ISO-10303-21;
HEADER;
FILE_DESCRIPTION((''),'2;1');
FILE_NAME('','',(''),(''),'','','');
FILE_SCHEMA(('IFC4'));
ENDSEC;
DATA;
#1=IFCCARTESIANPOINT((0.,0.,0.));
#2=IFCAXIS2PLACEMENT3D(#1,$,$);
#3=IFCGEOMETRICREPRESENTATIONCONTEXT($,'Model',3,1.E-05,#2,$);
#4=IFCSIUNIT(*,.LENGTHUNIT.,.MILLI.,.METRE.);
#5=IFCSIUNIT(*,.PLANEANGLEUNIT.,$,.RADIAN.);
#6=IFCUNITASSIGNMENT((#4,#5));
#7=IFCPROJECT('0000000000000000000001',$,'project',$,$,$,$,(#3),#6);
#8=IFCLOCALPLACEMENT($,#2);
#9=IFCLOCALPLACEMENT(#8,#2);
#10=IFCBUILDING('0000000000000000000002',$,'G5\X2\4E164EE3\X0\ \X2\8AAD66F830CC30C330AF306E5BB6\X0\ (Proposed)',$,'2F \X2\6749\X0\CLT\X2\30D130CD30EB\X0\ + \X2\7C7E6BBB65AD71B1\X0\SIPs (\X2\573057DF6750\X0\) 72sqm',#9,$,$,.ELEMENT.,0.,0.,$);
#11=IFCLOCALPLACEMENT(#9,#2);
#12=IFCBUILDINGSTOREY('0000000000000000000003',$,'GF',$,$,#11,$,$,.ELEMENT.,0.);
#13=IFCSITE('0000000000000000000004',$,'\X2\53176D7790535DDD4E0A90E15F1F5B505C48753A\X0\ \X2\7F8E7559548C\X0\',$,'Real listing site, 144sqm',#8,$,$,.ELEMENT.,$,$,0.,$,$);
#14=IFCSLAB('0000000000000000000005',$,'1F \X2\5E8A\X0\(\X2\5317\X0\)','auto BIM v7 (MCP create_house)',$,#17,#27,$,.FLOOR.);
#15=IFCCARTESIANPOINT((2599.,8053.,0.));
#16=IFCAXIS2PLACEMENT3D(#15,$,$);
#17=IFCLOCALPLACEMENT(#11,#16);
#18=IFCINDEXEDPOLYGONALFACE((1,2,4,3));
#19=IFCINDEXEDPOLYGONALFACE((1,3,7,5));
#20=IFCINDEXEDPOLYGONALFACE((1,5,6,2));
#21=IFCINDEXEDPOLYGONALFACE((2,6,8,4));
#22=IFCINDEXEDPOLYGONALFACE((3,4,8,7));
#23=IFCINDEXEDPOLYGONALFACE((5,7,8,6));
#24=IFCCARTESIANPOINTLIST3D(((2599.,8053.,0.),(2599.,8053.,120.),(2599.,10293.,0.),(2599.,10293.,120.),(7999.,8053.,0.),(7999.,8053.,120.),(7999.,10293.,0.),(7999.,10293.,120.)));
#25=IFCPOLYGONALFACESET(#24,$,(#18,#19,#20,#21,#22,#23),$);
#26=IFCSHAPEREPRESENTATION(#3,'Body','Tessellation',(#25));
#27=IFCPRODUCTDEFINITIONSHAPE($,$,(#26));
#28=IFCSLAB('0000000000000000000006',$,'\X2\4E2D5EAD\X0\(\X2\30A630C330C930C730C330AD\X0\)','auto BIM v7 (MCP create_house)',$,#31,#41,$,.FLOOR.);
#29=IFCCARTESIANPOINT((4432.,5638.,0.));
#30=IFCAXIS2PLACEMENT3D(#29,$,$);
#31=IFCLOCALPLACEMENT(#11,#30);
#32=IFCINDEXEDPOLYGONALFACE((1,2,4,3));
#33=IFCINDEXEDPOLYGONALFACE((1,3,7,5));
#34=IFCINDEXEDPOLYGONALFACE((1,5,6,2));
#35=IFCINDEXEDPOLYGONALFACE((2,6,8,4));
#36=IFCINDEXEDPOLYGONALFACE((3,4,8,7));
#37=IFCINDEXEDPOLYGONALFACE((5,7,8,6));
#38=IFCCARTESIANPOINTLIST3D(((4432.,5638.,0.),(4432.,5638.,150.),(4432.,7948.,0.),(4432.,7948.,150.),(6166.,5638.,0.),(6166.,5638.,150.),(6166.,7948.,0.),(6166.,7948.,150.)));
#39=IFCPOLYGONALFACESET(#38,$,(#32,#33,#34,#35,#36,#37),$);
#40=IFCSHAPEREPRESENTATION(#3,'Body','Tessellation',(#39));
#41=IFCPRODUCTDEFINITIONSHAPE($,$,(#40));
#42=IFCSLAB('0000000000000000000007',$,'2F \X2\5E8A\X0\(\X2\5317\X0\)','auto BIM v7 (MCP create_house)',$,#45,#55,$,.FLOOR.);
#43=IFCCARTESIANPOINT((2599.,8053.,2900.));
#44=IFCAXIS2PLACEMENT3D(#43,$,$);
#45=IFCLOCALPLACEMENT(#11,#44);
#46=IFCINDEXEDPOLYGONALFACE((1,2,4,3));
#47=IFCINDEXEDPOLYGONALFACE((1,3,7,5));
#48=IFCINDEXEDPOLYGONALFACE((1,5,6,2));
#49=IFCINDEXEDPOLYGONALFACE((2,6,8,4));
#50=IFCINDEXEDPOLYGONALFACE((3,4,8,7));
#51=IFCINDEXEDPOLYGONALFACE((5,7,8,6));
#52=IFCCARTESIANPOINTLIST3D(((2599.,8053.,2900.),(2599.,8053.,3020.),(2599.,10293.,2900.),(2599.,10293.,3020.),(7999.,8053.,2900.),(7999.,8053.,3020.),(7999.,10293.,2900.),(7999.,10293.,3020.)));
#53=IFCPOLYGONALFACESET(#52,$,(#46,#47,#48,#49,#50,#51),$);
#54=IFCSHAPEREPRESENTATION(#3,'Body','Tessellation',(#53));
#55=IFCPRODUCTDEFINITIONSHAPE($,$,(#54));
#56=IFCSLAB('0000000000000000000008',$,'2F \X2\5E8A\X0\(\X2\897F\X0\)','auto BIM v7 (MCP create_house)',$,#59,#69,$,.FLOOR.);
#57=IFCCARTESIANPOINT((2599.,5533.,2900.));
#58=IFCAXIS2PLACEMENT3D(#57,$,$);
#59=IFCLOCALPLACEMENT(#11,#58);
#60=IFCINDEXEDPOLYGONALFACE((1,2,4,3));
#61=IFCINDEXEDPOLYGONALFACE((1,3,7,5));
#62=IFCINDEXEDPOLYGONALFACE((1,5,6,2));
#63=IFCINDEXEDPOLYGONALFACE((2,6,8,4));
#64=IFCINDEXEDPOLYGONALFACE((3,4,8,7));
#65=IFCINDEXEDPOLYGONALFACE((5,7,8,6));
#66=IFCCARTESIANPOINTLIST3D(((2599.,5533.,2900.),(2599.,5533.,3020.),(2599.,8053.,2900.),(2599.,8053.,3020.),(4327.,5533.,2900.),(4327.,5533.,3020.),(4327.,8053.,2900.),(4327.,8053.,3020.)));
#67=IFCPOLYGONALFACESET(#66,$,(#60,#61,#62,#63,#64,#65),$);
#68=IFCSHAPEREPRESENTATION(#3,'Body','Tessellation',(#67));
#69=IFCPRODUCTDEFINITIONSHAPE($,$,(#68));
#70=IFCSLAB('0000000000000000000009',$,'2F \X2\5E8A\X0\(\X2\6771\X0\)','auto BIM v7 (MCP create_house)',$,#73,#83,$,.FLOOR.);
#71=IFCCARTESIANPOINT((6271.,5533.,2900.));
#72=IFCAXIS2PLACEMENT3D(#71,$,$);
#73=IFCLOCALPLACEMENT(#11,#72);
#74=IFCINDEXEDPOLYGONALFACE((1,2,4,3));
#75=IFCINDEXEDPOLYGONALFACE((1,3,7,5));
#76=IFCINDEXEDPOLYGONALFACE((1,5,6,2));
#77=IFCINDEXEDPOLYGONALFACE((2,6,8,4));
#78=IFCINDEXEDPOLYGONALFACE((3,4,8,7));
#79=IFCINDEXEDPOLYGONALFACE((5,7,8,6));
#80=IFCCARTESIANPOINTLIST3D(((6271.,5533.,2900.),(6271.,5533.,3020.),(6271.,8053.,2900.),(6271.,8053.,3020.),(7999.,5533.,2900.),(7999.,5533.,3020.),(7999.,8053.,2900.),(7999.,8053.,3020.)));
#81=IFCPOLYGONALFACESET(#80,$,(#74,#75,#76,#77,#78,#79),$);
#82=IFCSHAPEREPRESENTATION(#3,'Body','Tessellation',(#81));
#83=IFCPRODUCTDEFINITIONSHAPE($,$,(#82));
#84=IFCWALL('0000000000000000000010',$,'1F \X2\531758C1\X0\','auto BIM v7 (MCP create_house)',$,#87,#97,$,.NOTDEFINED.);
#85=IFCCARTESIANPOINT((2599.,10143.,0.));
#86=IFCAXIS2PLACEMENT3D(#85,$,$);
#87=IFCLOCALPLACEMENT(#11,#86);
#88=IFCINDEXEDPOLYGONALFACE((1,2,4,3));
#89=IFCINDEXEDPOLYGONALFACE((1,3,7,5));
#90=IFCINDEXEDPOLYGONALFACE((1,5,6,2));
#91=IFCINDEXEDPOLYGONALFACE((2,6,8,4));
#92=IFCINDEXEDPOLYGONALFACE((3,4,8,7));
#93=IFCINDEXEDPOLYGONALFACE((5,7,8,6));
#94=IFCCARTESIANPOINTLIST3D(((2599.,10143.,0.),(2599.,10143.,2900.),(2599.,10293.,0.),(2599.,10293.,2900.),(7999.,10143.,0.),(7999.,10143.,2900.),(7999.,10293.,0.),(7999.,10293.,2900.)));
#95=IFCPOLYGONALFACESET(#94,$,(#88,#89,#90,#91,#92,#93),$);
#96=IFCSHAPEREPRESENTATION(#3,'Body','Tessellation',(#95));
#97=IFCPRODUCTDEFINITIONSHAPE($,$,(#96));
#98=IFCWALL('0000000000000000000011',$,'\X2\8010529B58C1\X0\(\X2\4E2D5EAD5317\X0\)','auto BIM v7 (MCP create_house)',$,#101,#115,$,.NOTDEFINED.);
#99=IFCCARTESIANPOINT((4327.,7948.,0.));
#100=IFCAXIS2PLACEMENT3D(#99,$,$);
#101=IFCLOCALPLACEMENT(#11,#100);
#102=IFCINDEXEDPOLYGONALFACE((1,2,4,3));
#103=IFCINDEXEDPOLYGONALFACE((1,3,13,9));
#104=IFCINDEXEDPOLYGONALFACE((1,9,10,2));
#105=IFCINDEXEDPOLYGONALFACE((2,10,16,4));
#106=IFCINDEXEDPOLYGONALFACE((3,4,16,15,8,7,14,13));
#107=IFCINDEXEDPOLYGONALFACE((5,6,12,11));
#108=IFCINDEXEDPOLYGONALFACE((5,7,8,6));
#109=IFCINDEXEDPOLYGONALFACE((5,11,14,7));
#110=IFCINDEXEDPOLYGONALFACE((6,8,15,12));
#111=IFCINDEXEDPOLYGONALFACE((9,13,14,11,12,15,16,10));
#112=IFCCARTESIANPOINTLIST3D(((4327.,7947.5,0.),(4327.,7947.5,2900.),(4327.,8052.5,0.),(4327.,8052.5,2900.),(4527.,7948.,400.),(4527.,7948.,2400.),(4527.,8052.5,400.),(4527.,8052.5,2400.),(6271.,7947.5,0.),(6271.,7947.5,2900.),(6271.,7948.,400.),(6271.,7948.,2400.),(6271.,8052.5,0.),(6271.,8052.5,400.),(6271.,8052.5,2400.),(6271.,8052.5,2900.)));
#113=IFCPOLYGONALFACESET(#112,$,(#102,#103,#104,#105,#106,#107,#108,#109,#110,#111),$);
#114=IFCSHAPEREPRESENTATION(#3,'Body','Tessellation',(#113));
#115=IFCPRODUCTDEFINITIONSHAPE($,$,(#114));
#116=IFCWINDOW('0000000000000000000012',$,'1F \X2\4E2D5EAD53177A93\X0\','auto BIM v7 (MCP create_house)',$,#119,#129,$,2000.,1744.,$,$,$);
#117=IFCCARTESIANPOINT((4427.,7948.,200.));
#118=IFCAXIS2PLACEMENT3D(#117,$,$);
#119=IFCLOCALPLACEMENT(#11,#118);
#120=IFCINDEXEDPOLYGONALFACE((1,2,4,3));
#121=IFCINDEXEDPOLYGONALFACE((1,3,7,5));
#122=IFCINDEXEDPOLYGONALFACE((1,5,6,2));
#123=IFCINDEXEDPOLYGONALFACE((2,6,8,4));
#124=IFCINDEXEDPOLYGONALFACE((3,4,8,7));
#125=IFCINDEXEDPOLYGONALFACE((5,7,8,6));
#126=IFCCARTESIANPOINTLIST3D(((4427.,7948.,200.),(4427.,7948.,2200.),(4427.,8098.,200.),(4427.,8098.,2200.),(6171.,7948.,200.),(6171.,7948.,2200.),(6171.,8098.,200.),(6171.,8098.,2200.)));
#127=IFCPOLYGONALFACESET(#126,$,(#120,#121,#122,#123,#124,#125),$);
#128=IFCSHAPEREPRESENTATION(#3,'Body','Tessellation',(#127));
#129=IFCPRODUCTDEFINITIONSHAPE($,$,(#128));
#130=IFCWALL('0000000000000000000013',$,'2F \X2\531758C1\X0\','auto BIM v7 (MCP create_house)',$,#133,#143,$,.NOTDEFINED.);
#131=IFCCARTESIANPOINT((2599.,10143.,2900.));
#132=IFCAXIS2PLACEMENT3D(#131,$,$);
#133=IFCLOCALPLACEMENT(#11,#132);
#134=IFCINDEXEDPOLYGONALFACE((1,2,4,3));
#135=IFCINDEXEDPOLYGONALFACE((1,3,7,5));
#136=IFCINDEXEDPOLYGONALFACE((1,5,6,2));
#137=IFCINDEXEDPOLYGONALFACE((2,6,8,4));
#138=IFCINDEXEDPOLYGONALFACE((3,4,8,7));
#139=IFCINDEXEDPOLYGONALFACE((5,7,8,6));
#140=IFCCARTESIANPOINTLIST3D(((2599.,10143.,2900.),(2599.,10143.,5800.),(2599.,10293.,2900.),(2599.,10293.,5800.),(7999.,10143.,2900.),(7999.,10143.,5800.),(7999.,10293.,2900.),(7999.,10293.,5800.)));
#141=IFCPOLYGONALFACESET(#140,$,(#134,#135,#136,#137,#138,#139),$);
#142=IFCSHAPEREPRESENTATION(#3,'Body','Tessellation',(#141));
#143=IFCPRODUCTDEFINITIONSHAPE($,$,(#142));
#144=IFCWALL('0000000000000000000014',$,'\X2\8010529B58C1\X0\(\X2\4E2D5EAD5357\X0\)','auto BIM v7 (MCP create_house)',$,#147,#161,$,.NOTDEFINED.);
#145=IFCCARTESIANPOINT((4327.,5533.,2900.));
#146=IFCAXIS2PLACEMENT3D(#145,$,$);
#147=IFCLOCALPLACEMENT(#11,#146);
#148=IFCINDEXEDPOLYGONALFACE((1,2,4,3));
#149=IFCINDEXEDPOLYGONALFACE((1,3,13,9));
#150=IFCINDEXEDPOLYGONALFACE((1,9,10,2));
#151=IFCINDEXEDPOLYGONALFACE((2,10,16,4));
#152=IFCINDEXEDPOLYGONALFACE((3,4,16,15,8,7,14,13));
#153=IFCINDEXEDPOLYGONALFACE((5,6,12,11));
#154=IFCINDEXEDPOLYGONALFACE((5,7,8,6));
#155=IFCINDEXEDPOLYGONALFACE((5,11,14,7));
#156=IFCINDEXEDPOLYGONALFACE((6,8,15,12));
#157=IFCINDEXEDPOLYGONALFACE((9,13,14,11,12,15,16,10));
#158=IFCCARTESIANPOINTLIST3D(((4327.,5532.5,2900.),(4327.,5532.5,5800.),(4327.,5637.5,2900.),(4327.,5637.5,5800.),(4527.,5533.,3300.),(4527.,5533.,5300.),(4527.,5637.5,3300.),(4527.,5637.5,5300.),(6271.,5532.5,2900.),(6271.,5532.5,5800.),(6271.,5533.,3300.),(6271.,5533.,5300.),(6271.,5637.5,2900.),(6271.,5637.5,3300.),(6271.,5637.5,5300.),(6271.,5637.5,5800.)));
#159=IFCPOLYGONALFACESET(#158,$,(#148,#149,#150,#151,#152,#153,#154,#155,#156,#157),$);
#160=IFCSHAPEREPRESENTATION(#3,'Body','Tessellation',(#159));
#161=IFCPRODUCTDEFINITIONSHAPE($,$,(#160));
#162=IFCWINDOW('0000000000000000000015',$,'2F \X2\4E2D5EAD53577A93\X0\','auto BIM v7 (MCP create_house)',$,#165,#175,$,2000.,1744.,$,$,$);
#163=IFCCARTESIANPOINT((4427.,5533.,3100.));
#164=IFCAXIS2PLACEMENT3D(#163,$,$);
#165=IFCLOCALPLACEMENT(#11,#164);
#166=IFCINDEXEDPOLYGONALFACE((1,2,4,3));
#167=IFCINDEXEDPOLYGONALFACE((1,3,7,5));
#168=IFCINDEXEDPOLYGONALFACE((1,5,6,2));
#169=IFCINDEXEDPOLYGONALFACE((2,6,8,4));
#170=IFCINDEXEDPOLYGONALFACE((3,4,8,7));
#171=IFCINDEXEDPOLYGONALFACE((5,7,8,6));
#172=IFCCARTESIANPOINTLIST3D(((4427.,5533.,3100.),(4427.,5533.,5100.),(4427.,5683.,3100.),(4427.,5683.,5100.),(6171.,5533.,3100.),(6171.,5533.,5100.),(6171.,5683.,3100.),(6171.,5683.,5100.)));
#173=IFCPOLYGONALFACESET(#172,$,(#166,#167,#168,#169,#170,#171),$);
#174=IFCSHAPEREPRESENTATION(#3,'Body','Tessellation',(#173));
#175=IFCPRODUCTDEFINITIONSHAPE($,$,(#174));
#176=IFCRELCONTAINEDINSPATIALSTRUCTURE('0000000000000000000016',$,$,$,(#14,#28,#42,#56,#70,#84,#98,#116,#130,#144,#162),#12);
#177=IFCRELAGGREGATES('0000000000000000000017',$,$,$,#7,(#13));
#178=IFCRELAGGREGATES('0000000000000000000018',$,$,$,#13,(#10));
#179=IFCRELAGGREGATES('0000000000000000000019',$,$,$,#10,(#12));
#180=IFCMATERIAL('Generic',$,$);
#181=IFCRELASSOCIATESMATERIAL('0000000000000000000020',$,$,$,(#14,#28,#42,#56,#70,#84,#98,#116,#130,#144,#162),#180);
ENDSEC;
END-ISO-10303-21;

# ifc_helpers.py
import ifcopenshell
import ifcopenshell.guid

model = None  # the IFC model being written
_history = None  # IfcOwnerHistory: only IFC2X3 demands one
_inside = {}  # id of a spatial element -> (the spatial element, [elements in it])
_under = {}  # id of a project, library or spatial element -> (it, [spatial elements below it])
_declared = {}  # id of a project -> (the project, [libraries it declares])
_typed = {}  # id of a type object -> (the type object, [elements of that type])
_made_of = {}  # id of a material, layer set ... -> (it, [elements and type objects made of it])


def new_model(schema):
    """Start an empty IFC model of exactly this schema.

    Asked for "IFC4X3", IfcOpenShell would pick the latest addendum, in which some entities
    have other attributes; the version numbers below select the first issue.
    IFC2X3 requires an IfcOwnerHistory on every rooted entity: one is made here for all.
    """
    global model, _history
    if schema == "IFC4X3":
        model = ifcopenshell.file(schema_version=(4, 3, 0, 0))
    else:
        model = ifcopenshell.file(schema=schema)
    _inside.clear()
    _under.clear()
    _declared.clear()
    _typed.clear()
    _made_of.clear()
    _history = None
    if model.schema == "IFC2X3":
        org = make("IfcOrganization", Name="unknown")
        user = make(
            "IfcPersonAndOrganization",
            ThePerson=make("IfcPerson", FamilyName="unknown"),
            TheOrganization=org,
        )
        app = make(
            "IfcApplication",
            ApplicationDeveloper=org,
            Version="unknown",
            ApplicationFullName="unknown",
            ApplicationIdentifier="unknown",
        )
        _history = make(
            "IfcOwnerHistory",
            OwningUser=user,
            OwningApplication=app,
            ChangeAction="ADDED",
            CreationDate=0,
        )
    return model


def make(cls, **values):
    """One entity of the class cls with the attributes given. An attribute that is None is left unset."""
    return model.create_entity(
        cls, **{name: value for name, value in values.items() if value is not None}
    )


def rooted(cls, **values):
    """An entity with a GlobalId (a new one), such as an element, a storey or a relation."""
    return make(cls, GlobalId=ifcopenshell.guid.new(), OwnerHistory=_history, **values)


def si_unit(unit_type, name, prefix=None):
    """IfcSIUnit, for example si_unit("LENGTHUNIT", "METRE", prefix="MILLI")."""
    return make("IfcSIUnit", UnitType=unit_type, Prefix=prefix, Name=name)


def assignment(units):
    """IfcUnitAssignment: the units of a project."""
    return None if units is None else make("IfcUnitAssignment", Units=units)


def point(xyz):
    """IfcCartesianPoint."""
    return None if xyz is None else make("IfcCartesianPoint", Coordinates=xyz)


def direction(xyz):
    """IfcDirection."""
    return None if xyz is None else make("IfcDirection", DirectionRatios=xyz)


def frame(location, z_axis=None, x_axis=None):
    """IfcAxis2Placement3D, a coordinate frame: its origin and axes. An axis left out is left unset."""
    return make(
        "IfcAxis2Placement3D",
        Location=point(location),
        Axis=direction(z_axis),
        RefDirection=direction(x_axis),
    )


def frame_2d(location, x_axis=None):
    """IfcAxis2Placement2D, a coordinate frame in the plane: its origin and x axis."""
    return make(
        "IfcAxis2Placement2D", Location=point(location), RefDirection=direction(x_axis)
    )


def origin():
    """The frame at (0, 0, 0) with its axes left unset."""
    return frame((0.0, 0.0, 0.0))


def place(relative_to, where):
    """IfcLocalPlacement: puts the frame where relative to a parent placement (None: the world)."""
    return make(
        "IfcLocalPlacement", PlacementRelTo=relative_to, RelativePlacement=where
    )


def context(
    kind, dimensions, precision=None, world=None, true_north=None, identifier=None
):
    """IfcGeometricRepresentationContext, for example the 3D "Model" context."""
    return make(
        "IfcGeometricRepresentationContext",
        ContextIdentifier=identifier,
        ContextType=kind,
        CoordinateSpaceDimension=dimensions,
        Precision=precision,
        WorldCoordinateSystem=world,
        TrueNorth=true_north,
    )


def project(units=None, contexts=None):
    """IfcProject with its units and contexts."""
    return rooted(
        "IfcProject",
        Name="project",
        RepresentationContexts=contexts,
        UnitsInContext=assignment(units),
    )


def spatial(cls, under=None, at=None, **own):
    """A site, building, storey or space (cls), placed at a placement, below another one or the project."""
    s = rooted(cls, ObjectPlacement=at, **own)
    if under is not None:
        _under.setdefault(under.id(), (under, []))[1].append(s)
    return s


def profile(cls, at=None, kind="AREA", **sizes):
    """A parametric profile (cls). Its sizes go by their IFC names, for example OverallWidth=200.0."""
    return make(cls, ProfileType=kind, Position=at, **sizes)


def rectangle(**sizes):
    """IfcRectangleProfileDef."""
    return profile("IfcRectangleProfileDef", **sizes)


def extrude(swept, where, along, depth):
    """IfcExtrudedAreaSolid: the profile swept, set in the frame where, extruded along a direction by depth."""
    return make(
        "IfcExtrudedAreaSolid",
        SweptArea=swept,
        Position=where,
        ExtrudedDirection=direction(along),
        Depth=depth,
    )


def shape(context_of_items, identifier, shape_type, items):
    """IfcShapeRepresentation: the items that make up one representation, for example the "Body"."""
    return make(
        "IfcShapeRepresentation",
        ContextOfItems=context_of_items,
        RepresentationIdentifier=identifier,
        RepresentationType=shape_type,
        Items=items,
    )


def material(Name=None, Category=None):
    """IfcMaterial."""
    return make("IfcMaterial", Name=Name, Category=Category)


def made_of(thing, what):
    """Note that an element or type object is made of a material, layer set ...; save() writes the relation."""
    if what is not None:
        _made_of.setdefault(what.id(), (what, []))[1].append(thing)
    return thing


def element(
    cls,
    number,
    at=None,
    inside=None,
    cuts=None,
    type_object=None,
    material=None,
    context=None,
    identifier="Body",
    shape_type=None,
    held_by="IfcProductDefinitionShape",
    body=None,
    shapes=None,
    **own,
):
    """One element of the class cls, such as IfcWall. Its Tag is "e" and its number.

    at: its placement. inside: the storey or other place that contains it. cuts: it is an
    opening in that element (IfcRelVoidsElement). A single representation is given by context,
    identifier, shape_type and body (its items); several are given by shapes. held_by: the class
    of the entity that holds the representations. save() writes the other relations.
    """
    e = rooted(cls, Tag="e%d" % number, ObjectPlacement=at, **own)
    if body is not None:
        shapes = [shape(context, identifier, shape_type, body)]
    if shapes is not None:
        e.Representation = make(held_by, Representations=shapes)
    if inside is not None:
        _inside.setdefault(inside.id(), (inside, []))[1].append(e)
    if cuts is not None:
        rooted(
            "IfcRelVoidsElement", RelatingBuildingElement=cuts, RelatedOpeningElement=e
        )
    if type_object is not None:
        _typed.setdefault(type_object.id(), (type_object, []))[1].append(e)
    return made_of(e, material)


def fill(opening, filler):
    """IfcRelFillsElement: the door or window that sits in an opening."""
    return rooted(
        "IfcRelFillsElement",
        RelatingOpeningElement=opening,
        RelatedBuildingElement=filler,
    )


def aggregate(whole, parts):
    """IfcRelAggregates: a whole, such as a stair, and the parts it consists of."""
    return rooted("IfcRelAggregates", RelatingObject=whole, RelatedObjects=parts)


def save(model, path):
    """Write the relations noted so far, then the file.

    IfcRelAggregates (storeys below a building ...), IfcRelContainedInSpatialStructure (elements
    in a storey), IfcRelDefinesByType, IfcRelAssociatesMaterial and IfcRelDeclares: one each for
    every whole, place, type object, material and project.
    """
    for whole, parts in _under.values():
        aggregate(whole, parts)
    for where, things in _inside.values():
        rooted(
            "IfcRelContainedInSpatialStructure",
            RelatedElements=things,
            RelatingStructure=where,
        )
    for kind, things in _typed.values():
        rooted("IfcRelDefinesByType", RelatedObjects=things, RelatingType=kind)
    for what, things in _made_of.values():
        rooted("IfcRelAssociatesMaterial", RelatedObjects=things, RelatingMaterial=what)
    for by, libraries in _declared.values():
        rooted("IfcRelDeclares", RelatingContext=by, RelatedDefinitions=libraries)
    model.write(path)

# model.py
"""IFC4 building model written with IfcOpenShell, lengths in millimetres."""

from ifc_helpers import new_model, si_unit, frame, frame_2d, origin, place, context, project, spatial, rectangle, extrude, material, element, fill, save


model = new_model("IFC4")

# Units and contexts
model_context = context("Model", 3, precision=1e-05, world=origin())
ifc_project = project(units=[si_unit("LENGTHUNIT", "METRE", prefix="MILLI"), si_unit("PLANEANGLEUNIT", "RADIAN")], contexts=[model_context])

# Site, building, storey
site_placement = place(None, origin())
site = spatial("IfcSite", under=ifc_project, at=site_placement, Name="北海道川上郡弟子屈町 美留和", ObjectType="Real listing site, 144sqm", CompositionType="ELEMENT", RefElevation=0.0)
building_placement = place(site_placement, origin())
building = spatial("IfcBuilding", under=site, at=building_placement, Name="G5世代 読書ヌックの家 (Proposed)", ObjectType="2F 杉CLTパネル + 籾殻断熱SIPs (地域材) 72sqm", CompositionType="ELEMENT", ElevationOfRefHeight=0.0, ElevationOfTerrain=0.0)
storey_placement = place(building_placement, origin())
storey = spatial("IfcBuildingStorey", under=building, at=storey_placement, Name="GF", CompositionType="ELEMENT", Elevation=0.0)

# Slabs
ifc_material = material(Name="Generic")
slab_1_placement = place(storey_placement, frame((2599.0, 8053.0, 0.0)))
element("IfcSlab", 1, at=slab_1_placement, inside=storey, material=ifc_material, Name="1F 床(北)", Description="auto BIM v7 (MCP create_house)", PredefinedType="FLOOR", context=model_context, shape_type="SweptSolid", body=[
    extrude(rectangle(XDim=5400.0, YDim=2240.0, at=frame_2d((2700.0, 1120.0))), frame((2599.0, 8053.0, 0.0)), (0.0, 0.0, 1.0), 120.0),
])
slab_2_placement = place(storey_placement, frame((4432.0, 5638.0, 0.0)))
element("IfcSlab", 2, at=slab_2_placement, inside=storey, material=ifc_material, Name="中庭(ウッドデッキ)", Description="auto BIM v7 (MCP create_house)", PredefinedType="FLOOR", context=model_context, shape_type="SweptSolid", body=[
    extrude(rectangle(XDim=1734.0, YDim=2310.0, at=frame_2d((867.0, 1155.0))), frame((4432.0, 5638.0, 0.0)), (0.0, 0.0, 1.0), 150.0),
])
slab_3_placement = place(storey_placement, frame((2599.0, 8053.0, 2900.0)))
element("IfcSlab", 3, at=slab_3_placement, inside=storey, material=ifc_material, Name="2F 床(北)", Description="auto BIM v7 (MCP create_house)", PredefinedType="FLOOR", context=model_context, shape_type="SweptSolid", body=[
    extrude(rectangle(XDim=5400.0, YDim=2240.0, at=frame_2d((2700.0, 1120.0))), frame((2599.0, 8053.0, 2900.0)), (0.0, 0.0, 1.0), 120.0),
])
slab_4_placement = place(storey_placement, frame((2599.0, 5533.0, 2900.0)))
element("IfcSlab", 4, at=slab_4_placement, inside=storey, material=ifc_material, Name="2F 床(西)", Description="auto BIM v7 (MCP create_house)", PredefinedType="FLOOR", context=model_context, shape_type="SweptSolid", body=[
    extrude(rectangle(XDim=1728.0, YDim=2520.0, at=frame_2d((864.0, 1260.0))), frame((2599.0, 5533.0, 2900.0)), (0.0, 0.0, 1.0), 120.0),
])
slab_5_placement = place(storey_placement, frame((6271.0, 5533.0, 2900.0)))
element("IfcSlab", 5, at=slab_5_placement, inside=storey, material=ifc_material, Name="2F 床(東)", Description="auto BIM v7 (MCP create_house)", PredefinedType="FLOOR", context=model_context, shape_type="SweptSolid", body=[
    extrude(rectangle(XDim=1728.0, YDim=2520.0, at=frame_2d((864.0, 1260.0))), frame((6271.0, 5533.0, 2900.0)), (0.0, 0.0, 1.0), 120.0),
])

# Wall
wall_1_placement = place(storey_placement, frame((2599.0, 10143.0, 0.0)))
element("IfcWall", 6, at=wall_1_placement, inside=storey, material=ifc_material, Name="1F 北壁", Description="auto BIM v7 (MCP create_house)", PredefinedType="NOTDEFINED", context=model_context, shape_type="SweptSolid", body=[
    extrude(rectangle(XDim=5400.0, YDim=150.0, at=frame_2d((2700.0, 75.0))), frame((2599.0, 10143.0, 0.0)), (0.0, 0.0, 1.0), 2900.0),
])

# Wall, opening, window
wall_2_placement = place(storey_placement, frame((4327.0, 7948.0, 0.0)))
wall_2 = element("IfcWall", 7, at=wall_2_placement, inside=storey, material=ifc_material, Name="耐力壁(中庭北)", Description="auto BIM v7 (MCP create_house)", PredefinedType="NOTDEFINED", context=model_context, shape_type="SweptSolid", body=[
    extrude(rectangle(XDim=1944.0, YDim=105.0, at=frame_2d((972.0, 52.0))), frame((4327.0, 7948.0, 0.0)), (0.0, 0.0, 1.0), 2900.0),
])
opening_1_placement = place(storey_placement, frame((4427.0, 7948.0, 200.0)))
opening_1 = element("IfcOpeningElement", 8, at=opening_1_placement, cuts=wall_2, PredefinedType="NOTDEFINED", context=model_context, shape_type="SweptSolid", body=[
    extrude(rectangle(XDim=1744.0, YDim=150.0, at=frame_2d((872.0, 75.0))), frame((4427.0, 7948.0, 200.0)), (0.0, 0.0, 1.0), 2000.0),
])
window_1_placement = place(storey_placement, frame((4427.0, 7948.0, 200.0)))
window_1 = element("IfcWindow", 9, at=window_1_placement, inside=storey, material=ifc_material, Name="1F 中庭北窓", Description="auto BIM v7 (MCP create_house)", OverallHeight=2000.0, OverallWidth=1744.0, context=model_context, shape_type="SweptSolid", body=[
    extrude(rectangle(XDim=1744.0, YDim=150.0, at=frame_2d((872.0, 75.0))), frame((4427.0, 7948.0, 200.0)), (0.0, 0.0, 1.0), 2000.0),
])
fill(opening_1, window_1)

# Wall
wall_3_placement = place(storey_placement, frame((2599.0, 10143.0, 2900.0)))
element("IfcWall", 10, at=wall_3_placement, inside=storey, material=ifc_material, Name="2F 北壁", Description="auto BIM v7 (MCP create_house)", PredefinedType="NOTDEFINED", context=model_context, shape_type="SweptSolid", body=[
    extrude(rectangle(XDim=5400.0, YDim=150.0, at=frame_2d((2700.0, 75.0))), frame((2599.0, 10143.0, 2900.0)), (0.0, 0.0, 1.0), 2900.0),
])

# Wall, opening, window
wall_4_placement = place(storey_placement, frame((4327.0, 5533.0, 2900.0)))
wall_4 = element("IfcWall", 11, at=wall_4_placement, inside=storey, material=ifc_material, Name="耐力壁(中庭南)", Description="auto BIM v7 (MCP create_house)", PredefinedType="NOTDEFINED", context=model_context, shape_type="SweptSolid", body=[
    extrude(rectangle(XDim=1944.0, YDim=105.0, at=frame_2d((972.0, 52.0))), frame((4327.0, 5533.0, 2900.0)), (0.0, 0.0, 1.0), 2900.0),
])
opening_2_placement = place(storey_placement, frame((4427.0, 5533.0, 3100.0)))
opening_2 = element("IfcOpeningElement", 12, at=opening_2_placement, cuts=wall_4, PredefinedType="NOTDEFINED", context=model_context, shape_type="SweptSolid", body=[
    extrude(rectangle(XDim=1744.0, YDim=150.0, at=frame_2d((872.0, 75.0))), frame((4427.0, 5533.0, 3100.0)), (0.0, 0.0, 1.0), 2000.0),
])
window_2_placement = place(storey_placement, frame((4427.0, 5533.0, 3100.0)))
window_2 = element("IfcWindow", 13, at=window_2_placement, inside=storey, material=ifc_material, Name="2F 中庭南窓", Description="auto BIM v7 (MCP create_house)", OverallHeight=2000.0, OverallWidth=1744.0, context=model_context, shape_type="SweptSolid", body=[
    extrude(rectangle(XDim=1744.0, YDim=150.0, at=frame_2d((872.0, 75.0))), frame((4427.0, 5533.0, 3100.0)), (0.0, 0.0, 1.0), 2000.0),
])
fill(opening_2, window_2)

save(model, "model.ifc")
